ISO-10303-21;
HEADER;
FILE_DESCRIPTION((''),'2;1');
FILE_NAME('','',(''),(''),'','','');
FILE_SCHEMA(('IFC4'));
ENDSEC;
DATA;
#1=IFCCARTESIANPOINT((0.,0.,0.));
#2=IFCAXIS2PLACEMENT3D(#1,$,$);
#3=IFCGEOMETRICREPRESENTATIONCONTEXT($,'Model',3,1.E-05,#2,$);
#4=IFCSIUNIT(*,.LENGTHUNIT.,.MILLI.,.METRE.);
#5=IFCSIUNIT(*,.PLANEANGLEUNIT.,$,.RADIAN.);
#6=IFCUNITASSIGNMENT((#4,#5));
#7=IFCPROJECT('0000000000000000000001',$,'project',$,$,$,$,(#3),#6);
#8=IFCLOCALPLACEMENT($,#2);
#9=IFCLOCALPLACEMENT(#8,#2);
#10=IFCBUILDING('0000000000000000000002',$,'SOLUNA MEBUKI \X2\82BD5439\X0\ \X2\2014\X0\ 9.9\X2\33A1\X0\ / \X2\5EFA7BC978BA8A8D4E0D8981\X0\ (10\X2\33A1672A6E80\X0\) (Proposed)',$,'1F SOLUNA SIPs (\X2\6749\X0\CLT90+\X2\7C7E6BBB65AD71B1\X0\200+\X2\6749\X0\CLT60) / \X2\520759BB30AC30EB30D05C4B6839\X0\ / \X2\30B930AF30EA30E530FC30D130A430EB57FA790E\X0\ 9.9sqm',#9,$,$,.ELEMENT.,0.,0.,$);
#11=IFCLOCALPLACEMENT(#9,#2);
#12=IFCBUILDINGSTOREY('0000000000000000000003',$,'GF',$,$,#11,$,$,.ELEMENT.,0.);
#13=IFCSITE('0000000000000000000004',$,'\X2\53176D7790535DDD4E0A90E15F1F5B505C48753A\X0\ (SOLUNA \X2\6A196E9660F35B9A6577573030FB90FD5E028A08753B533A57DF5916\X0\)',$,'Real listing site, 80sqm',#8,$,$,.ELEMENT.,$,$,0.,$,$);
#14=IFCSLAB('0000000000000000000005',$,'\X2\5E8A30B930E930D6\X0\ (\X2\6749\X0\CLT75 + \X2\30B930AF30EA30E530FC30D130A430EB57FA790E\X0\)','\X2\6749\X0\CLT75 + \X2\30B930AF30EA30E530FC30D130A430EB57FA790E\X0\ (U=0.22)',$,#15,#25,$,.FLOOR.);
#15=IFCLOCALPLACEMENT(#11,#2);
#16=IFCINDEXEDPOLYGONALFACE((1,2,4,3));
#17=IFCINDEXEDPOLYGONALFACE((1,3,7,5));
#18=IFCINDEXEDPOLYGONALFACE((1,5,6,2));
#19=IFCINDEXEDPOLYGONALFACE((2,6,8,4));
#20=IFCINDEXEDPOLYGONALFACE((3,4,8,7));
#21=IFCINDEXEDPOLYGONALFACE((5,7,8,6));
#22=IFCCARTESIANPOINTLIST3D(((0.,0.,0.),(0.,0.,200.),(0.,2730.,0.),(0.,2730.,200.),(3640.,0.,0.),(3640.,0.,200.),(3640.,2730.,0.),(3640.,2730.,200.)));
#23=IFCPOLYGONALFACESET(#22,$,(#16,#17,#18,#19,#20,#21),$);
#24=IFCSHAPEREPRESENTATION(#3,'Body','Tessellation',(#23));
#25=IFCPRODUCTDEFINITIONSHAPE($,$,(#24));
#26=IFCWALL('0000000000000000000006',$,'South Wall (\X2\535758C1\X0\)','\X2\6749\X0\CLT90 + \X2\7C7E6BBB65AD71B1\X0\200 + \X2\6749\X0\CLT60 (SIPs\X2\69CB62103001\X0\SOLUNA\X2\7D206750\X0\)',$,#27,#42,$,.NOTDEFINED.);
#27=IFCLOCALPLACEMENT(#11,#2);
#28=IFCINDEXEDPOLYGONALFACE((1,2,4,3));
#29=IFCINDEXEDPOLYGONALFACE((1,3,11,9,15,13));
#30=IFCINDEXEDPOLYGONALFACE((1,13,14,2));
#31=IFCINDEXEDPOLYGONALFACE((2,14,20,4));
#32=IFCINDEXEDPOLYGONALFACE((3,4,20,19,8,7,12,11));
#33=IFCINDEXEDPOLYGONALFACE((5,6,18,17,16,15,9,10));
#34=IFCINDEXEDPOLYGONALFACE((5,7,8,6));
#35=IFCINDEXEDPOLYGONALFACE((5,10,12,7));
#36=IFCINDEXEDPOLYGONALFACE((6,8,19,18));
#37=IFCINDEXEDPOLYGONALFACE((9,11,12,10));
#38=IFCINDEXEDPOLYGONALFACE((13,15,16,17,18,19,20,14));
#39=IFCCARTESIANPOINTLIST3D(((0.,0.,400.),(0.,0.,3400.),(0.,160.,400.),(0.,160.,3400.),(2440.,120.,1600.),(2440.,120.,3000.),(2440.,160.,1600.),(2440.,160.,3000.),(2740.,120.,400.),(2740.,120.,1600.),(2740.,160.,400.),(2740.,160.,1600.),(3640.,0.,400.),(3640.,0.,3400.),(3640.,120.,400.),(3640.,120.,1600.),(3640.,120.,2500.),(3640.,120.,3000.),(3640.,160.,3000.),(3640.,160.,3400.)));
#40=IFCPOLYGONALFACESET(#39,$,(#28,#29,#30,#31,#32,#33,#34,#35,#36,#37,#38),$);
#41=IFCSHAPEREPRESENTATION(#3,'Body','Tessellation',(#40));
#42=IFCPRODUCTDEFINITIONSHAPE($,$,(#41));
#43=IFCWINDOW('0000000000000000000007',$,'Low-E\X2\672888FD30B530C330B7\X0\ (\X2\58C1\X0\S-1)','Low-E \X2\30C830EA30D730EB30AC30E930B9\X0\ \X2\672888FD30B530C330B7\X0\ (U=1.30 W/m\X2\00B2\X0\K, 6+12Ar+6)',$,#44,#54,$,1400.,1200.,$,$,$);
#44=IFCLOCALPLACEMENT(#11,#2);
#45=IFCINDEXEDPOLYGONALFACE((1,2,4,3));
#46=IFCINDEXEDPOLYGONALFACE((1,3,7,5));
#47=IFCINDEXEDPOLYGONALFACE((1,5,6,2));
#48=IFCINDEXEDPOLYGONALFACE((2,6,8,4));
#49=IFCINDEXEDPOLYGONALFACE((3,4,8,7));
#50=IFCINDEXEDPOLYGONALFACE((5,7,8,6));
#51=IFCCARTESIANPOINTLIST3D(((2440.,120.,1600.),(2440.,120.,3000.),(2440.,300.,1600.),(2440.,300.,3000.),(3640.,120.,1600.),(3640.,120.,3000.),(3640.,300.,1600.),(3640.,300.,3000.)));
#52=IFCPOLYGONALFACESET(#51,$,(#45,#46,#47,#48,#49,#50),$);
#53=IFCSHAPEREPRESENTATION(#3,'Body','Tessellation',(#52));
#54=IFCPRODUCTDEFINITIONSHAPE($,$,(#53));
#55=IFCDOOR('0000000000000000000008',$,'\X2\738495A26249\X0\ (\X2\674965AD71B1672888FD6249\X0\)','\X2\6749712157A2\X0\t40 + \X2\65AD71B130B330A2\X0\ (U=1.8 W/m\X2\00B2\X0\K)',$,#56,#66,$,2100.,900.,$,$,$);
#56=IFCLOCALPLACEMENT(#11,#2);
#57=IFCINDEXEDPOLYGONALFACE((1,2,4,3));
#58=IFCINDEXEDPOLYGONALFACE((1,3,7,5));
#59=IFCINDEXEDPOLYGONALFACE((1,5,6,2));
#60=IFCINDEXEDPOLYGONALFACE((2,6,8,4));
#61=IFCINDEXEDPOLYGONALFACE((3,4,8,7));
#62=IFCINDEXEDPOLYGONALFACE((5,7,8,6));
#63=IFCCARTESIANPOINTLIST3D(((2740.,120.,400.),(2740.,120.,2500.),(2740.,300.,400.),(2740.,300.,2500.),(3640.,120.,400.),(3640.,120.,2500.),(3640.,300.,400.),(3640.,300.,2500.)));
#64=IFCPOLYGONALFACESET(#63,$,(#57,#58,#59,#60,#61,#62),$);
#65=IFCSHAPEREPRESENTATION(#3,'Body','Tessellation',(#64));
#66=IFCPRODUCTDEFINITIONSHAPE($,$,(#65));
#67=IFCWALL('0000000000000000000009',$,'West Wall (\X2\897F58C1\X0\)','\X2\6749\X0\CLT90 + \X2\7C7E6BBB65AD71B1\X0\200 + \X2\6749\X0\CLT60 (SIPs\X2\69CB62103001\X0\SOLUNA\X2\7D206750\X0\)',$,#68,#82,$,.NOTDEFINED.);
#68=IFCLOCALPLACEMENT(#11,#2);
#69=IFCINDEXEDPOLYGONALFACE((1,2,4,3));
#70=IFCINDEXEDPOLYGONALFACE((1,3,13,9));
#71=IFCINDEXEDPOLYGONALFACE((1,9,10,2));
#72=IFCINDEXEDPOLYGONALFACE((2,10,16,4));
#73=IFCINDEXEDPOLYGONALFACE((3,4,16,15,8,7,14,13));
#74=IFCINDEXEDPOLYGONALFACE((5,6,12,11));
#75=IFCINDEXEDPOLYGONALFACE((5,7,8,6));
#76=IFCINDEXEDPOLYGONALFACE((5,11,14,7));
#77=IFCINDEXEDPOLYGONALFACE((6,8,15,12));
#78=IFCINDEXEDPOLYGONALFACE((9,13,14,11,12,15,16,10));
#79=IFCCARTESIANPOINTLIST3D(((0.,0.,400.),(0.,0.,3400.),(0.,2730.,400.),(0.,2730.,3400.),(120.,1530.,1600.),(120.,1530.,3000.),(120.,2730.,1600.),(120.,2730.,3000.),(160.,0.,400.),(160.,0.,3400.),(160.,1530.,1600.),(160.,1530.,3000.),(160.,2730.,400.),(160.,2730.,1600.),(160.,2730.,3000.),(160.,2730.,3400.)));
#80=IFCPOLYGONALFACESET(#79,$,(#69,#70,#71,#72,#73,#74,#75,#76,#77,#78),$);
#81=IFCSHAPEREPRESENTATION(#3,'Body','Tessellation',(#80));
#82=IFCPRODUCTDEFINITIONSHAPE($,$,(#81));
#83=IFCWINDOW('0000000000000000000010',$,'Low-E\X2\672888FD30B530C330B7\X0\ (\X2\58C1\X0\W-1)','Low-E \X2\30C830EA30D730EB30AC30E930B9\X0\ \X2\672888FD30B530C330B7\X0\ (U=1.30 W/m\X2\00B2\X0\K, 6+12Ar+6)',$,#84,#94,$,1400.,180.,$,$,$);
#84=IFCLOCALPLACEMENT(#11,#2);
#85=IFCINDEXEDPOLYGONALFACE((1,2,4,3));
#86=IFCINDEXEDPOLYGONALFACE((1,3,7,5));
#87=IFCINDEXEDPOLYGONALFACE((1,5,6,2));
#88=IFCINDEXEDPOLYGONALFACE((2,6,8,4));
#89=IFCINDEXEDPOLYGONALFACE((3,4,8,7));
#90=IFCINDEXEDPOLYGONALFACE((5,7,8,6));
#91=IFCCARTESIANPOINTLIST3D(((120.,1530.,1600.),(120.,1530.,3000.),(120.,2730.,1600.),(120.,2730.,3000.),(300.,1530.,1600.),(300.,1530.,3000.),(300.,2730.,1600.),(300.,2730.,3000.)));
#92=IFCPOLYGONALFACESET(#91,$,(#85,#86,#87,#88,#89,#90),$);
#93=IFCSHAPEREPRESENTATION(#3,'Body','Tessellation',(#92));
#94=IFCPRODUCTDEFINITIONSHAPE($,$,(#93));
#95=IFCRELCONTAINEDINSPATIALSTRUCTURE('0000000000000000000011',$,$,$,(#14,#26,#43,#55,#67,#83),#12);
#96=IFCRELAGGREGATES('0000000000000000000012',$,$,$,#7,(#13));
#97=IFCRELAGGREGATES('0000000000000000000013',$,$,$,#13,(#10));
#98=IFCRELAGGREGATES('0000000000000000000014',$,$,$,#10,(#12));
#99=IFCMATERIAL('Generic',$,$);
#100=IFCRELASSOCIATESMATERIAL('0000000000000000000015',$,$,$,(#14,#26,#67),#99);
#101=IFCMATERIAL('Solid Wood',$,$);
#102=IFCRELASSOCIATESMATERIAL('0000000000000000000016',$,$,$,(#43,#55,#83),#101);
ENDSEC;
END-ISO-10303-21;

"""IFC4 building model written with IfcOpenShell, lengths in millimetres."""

from ifc_helpers import new_model, si_unit, frame, frame_2d, origin, place, context, project, spatial, rectangle, extrude, material, element, fill, save


model = new_model("IFC4")

# Units and contexts
model_context = context("Model", 3, precision=1e-05, world=origin())
ifc_project = project(units=[si_unit("LENGTHUNIT", "METRE", prefix="MILLI"), si_unit("PLANEANGLEUNIT", "RADIAN")], contexts=[model_context])

# Site, building, storey
site_placement = place(None, origin())
site = spatial("IfcSite", under=ifc_project, at=site_placement, Name="北海道川上郡弟子屈町 (SOLUNA 標準想定敷地・都市計画区域外)", ObjectType="Real listing site, 80sqm", CompositionType="ELEMENT", RefElevation=0.0)
building_placement = place(site_placement, origin())
building = spatial("IfcBuilding", under=site, at=building_placement, Name="SOLUNA MEBUKI 芽吹 — 9.9㎡ / 建築確認不要 (10㎡未満) (Proposed)", ObjectType="1F SOLUNA SIPs (杉CLT90+籾殻断熱200+杉CLT60) / 切妻ガルバ屋根 / スクリューパイル基礎 9.9sqm", CompositionType="ELEMENT", ElevationOfRefHeight=0.0, ElevationOfTerrain=0.0)
storey_placement = place(building_placement, origin())
storey = spatial("IfcBuildingStorey", under=building, at=storey_placement, Name="GF", CompositionType="ELEMENT", Elevation=0.0)

# Slab
ifc_material_1 = material(Name="Generic")
slab_placement = place(storey_placement, origin())
element("IfcSlab", 1, at=slab_placement, inside=storey, material=ifc_material_1, Name="床スラブ (杉CLT75 + スクリューパイル基礎)", Description="杉CLT75 + スクリューパイル基礎 (U=0.22)", PredefinedType="FLOOR", context=model_context, shape_type="SweptSolid", body=[
    extrude(rectangle(XDim=3640.0, YDim=2730.0, at=frame_2d((1820.0, 1365.0))), origin(), (0.0, 0.0, 1.0), 200.0),
])

# Wall, openings, window, door
wall_1_placement = place(storey_placement, frame((0.0, 0.0, 200.0)))
wall_1 = element("IfcWall", 2, at=wall_1_placement, inside=storey, material=ifc_material_1, Name="South Wall (南壁)", Description="杉CLT90 + 籾殻断熱200 + 杉CLT60 (SIPs構成、SOLUNA素材)", PredefinedType="NOTDEFINED", context=model_context, shape_type="SweptSolid", body=[
    extrude(rectangle(XDim=3640.0, YDim=160.0, at=frame_2d((1820.0, 80.0))), frame((0.0, 0.0, 200.0)), (0.0, 0.0, 1.0), 3000.0),
])
opening_1_placement = place(storey_placement, frame((1220.0, 60.0, 800.0)))
opening_1 = element("IfcOpeningElement", 3, at=opening_1_placement, cuts=wall_1, PredefinedType="NOTDEFINED", context=model_context, shape_type="SweptSolid", body=[
    extrude(rectangle(XDim=1200.0, YDim=180.0, at=frame_2d((600.0, 90.0))), frame((1220.0, 60.0, 800.0)), (0.0, 0.0, 1.0), 1400.0),
])
opening_2_placement = place(storey_placement, frame((1370.0, 60.0, 200.0)))
opening_2 = element("IfcOpeningElement", 4, at=opening_2_placement, cuts=wall_1, PredefinedType="NOTDEFINED", context=model_context, shape_type="SweptSolid", body=[
    extrude(rectangle(XDim=900.0, YDim=180.0, at=frame_2d((450.0, 90.0))), frame((1370.0, 60.0, 200.0)), (0.0, 0.0, 1.0), 2100.0),
])
ifc_material_2 = material(Name="Solid Wood")
window_1_placement = place(storey_placement, frame((1220.0, 60.0, 800.0)))
window_1 = element("IfcWindow", 5, at=window_1_placement, inside=storey, material=ifc_material_2, Name="Low-E木製サッシ (壁S-1)", Description="Low-E トリプルガラス 木製サッシ (U=1.30 W/m²K, 6+12Ar+6)", OverallHeight=1400.0, OverallWidth=1200.0, context=model_context, shape_type="SweptSolid", body=[
    extrude(rectangle(XDim=1200.0, YDim=180.0, at=frame_2d((600.0, 90.0))), frame((1220.0, 60.0, 800.0)), (0.0, 0.0, 1.0), 1400.0),
])
fill(opening_1, window_1)
door_placement = place(storey_placement, frame((1370.0, 60.0, 200.0)))
door = element("IfcDoor", 6, at=door_placement, inside=storey, material=ifc_material_2, Name="玄関扉 (杉断熱木製扉)", Description="杉無垢t40 + 断熱コア (U=1.8 W/m²K)", OverallHeight=2100.0, OverallWidth=900.0, context=model_context, shape_type="SweptSolid", body=[
    extrude(rectangle(XDim=900.0, YDim=180.0, at=frame_2d((450.0, 90.0))), frame((1370.0, 60.0, 200.0)), (0.0, 0.0, 1.0), 2100.0),
])
fill(opening_2, door)

# Wall, opening, window
wall_2_placement = place(storey_placement, frame((0.0, 0.0, 200.0)))
wall_2 = element("IfcWall", 7, at=wall_2_placement, inside=storey, material=ifc_material_1, Name="West Wall (西壁)", Description="杉CLT90 + 籾殻断熱200 + 杉CLT60 (SIPs構成、SOLUNA素材)", PredefinedType="NOTDEFINED", context=model_context, shape_type="SweptSolid", body=[
    extrude(rectangle(XDim=160.0, YDim=2730.0, at=frame_2d((80.0, 1365.0))), frame((0.0, 0.0, 200.0)), (0.0, 0.0, 1.0), 3000.0),
])
opening_3_placement = place(storey_placement, frame((60.0, 765.0, 800.0)))
opening_3 = element("IfcOpeningElement", 8, at=opening_3_placement, cuts=wall_2, PredefinedType="NOTDEFINED", context=model_context, shape_type="SweptSolid", body=[
    extrude(rectangle(XDim=180.0, YDim=1200.0, at=frame_2d((90.0, 600.0))), frame((60.0, 765.0, 800.0)), (0.0, 0.0, 1.0), 1400.0),
])
window_2_placement = place(storey_placement, frame((60.0, 765.0, 800.0)))
window_2 = element("IfcWindow", 9, at=window_2_placement, inside=storey, material=ifc_material_2, Name="Low-E木製サッシ (壁W-1)", Description="Low-E トリプルガラス 木製サッシ (U=1.30 W/m²K, 6+12Ar+6)", OverallHeight=1400.0, OverallWidth=180.0, context=model_context, shape_type="SweptSolid", body=[
    extrude(rectangle(XDim=180.0, YDim=1200.0, at=frame_2d((90.0, 600.0))), frame((60.0, 765.0, 800.0)), (0.0, 0.0, 1.0), 1400.0),
])
fill(opening_3, window_2)

save(model, "model.ifc")
